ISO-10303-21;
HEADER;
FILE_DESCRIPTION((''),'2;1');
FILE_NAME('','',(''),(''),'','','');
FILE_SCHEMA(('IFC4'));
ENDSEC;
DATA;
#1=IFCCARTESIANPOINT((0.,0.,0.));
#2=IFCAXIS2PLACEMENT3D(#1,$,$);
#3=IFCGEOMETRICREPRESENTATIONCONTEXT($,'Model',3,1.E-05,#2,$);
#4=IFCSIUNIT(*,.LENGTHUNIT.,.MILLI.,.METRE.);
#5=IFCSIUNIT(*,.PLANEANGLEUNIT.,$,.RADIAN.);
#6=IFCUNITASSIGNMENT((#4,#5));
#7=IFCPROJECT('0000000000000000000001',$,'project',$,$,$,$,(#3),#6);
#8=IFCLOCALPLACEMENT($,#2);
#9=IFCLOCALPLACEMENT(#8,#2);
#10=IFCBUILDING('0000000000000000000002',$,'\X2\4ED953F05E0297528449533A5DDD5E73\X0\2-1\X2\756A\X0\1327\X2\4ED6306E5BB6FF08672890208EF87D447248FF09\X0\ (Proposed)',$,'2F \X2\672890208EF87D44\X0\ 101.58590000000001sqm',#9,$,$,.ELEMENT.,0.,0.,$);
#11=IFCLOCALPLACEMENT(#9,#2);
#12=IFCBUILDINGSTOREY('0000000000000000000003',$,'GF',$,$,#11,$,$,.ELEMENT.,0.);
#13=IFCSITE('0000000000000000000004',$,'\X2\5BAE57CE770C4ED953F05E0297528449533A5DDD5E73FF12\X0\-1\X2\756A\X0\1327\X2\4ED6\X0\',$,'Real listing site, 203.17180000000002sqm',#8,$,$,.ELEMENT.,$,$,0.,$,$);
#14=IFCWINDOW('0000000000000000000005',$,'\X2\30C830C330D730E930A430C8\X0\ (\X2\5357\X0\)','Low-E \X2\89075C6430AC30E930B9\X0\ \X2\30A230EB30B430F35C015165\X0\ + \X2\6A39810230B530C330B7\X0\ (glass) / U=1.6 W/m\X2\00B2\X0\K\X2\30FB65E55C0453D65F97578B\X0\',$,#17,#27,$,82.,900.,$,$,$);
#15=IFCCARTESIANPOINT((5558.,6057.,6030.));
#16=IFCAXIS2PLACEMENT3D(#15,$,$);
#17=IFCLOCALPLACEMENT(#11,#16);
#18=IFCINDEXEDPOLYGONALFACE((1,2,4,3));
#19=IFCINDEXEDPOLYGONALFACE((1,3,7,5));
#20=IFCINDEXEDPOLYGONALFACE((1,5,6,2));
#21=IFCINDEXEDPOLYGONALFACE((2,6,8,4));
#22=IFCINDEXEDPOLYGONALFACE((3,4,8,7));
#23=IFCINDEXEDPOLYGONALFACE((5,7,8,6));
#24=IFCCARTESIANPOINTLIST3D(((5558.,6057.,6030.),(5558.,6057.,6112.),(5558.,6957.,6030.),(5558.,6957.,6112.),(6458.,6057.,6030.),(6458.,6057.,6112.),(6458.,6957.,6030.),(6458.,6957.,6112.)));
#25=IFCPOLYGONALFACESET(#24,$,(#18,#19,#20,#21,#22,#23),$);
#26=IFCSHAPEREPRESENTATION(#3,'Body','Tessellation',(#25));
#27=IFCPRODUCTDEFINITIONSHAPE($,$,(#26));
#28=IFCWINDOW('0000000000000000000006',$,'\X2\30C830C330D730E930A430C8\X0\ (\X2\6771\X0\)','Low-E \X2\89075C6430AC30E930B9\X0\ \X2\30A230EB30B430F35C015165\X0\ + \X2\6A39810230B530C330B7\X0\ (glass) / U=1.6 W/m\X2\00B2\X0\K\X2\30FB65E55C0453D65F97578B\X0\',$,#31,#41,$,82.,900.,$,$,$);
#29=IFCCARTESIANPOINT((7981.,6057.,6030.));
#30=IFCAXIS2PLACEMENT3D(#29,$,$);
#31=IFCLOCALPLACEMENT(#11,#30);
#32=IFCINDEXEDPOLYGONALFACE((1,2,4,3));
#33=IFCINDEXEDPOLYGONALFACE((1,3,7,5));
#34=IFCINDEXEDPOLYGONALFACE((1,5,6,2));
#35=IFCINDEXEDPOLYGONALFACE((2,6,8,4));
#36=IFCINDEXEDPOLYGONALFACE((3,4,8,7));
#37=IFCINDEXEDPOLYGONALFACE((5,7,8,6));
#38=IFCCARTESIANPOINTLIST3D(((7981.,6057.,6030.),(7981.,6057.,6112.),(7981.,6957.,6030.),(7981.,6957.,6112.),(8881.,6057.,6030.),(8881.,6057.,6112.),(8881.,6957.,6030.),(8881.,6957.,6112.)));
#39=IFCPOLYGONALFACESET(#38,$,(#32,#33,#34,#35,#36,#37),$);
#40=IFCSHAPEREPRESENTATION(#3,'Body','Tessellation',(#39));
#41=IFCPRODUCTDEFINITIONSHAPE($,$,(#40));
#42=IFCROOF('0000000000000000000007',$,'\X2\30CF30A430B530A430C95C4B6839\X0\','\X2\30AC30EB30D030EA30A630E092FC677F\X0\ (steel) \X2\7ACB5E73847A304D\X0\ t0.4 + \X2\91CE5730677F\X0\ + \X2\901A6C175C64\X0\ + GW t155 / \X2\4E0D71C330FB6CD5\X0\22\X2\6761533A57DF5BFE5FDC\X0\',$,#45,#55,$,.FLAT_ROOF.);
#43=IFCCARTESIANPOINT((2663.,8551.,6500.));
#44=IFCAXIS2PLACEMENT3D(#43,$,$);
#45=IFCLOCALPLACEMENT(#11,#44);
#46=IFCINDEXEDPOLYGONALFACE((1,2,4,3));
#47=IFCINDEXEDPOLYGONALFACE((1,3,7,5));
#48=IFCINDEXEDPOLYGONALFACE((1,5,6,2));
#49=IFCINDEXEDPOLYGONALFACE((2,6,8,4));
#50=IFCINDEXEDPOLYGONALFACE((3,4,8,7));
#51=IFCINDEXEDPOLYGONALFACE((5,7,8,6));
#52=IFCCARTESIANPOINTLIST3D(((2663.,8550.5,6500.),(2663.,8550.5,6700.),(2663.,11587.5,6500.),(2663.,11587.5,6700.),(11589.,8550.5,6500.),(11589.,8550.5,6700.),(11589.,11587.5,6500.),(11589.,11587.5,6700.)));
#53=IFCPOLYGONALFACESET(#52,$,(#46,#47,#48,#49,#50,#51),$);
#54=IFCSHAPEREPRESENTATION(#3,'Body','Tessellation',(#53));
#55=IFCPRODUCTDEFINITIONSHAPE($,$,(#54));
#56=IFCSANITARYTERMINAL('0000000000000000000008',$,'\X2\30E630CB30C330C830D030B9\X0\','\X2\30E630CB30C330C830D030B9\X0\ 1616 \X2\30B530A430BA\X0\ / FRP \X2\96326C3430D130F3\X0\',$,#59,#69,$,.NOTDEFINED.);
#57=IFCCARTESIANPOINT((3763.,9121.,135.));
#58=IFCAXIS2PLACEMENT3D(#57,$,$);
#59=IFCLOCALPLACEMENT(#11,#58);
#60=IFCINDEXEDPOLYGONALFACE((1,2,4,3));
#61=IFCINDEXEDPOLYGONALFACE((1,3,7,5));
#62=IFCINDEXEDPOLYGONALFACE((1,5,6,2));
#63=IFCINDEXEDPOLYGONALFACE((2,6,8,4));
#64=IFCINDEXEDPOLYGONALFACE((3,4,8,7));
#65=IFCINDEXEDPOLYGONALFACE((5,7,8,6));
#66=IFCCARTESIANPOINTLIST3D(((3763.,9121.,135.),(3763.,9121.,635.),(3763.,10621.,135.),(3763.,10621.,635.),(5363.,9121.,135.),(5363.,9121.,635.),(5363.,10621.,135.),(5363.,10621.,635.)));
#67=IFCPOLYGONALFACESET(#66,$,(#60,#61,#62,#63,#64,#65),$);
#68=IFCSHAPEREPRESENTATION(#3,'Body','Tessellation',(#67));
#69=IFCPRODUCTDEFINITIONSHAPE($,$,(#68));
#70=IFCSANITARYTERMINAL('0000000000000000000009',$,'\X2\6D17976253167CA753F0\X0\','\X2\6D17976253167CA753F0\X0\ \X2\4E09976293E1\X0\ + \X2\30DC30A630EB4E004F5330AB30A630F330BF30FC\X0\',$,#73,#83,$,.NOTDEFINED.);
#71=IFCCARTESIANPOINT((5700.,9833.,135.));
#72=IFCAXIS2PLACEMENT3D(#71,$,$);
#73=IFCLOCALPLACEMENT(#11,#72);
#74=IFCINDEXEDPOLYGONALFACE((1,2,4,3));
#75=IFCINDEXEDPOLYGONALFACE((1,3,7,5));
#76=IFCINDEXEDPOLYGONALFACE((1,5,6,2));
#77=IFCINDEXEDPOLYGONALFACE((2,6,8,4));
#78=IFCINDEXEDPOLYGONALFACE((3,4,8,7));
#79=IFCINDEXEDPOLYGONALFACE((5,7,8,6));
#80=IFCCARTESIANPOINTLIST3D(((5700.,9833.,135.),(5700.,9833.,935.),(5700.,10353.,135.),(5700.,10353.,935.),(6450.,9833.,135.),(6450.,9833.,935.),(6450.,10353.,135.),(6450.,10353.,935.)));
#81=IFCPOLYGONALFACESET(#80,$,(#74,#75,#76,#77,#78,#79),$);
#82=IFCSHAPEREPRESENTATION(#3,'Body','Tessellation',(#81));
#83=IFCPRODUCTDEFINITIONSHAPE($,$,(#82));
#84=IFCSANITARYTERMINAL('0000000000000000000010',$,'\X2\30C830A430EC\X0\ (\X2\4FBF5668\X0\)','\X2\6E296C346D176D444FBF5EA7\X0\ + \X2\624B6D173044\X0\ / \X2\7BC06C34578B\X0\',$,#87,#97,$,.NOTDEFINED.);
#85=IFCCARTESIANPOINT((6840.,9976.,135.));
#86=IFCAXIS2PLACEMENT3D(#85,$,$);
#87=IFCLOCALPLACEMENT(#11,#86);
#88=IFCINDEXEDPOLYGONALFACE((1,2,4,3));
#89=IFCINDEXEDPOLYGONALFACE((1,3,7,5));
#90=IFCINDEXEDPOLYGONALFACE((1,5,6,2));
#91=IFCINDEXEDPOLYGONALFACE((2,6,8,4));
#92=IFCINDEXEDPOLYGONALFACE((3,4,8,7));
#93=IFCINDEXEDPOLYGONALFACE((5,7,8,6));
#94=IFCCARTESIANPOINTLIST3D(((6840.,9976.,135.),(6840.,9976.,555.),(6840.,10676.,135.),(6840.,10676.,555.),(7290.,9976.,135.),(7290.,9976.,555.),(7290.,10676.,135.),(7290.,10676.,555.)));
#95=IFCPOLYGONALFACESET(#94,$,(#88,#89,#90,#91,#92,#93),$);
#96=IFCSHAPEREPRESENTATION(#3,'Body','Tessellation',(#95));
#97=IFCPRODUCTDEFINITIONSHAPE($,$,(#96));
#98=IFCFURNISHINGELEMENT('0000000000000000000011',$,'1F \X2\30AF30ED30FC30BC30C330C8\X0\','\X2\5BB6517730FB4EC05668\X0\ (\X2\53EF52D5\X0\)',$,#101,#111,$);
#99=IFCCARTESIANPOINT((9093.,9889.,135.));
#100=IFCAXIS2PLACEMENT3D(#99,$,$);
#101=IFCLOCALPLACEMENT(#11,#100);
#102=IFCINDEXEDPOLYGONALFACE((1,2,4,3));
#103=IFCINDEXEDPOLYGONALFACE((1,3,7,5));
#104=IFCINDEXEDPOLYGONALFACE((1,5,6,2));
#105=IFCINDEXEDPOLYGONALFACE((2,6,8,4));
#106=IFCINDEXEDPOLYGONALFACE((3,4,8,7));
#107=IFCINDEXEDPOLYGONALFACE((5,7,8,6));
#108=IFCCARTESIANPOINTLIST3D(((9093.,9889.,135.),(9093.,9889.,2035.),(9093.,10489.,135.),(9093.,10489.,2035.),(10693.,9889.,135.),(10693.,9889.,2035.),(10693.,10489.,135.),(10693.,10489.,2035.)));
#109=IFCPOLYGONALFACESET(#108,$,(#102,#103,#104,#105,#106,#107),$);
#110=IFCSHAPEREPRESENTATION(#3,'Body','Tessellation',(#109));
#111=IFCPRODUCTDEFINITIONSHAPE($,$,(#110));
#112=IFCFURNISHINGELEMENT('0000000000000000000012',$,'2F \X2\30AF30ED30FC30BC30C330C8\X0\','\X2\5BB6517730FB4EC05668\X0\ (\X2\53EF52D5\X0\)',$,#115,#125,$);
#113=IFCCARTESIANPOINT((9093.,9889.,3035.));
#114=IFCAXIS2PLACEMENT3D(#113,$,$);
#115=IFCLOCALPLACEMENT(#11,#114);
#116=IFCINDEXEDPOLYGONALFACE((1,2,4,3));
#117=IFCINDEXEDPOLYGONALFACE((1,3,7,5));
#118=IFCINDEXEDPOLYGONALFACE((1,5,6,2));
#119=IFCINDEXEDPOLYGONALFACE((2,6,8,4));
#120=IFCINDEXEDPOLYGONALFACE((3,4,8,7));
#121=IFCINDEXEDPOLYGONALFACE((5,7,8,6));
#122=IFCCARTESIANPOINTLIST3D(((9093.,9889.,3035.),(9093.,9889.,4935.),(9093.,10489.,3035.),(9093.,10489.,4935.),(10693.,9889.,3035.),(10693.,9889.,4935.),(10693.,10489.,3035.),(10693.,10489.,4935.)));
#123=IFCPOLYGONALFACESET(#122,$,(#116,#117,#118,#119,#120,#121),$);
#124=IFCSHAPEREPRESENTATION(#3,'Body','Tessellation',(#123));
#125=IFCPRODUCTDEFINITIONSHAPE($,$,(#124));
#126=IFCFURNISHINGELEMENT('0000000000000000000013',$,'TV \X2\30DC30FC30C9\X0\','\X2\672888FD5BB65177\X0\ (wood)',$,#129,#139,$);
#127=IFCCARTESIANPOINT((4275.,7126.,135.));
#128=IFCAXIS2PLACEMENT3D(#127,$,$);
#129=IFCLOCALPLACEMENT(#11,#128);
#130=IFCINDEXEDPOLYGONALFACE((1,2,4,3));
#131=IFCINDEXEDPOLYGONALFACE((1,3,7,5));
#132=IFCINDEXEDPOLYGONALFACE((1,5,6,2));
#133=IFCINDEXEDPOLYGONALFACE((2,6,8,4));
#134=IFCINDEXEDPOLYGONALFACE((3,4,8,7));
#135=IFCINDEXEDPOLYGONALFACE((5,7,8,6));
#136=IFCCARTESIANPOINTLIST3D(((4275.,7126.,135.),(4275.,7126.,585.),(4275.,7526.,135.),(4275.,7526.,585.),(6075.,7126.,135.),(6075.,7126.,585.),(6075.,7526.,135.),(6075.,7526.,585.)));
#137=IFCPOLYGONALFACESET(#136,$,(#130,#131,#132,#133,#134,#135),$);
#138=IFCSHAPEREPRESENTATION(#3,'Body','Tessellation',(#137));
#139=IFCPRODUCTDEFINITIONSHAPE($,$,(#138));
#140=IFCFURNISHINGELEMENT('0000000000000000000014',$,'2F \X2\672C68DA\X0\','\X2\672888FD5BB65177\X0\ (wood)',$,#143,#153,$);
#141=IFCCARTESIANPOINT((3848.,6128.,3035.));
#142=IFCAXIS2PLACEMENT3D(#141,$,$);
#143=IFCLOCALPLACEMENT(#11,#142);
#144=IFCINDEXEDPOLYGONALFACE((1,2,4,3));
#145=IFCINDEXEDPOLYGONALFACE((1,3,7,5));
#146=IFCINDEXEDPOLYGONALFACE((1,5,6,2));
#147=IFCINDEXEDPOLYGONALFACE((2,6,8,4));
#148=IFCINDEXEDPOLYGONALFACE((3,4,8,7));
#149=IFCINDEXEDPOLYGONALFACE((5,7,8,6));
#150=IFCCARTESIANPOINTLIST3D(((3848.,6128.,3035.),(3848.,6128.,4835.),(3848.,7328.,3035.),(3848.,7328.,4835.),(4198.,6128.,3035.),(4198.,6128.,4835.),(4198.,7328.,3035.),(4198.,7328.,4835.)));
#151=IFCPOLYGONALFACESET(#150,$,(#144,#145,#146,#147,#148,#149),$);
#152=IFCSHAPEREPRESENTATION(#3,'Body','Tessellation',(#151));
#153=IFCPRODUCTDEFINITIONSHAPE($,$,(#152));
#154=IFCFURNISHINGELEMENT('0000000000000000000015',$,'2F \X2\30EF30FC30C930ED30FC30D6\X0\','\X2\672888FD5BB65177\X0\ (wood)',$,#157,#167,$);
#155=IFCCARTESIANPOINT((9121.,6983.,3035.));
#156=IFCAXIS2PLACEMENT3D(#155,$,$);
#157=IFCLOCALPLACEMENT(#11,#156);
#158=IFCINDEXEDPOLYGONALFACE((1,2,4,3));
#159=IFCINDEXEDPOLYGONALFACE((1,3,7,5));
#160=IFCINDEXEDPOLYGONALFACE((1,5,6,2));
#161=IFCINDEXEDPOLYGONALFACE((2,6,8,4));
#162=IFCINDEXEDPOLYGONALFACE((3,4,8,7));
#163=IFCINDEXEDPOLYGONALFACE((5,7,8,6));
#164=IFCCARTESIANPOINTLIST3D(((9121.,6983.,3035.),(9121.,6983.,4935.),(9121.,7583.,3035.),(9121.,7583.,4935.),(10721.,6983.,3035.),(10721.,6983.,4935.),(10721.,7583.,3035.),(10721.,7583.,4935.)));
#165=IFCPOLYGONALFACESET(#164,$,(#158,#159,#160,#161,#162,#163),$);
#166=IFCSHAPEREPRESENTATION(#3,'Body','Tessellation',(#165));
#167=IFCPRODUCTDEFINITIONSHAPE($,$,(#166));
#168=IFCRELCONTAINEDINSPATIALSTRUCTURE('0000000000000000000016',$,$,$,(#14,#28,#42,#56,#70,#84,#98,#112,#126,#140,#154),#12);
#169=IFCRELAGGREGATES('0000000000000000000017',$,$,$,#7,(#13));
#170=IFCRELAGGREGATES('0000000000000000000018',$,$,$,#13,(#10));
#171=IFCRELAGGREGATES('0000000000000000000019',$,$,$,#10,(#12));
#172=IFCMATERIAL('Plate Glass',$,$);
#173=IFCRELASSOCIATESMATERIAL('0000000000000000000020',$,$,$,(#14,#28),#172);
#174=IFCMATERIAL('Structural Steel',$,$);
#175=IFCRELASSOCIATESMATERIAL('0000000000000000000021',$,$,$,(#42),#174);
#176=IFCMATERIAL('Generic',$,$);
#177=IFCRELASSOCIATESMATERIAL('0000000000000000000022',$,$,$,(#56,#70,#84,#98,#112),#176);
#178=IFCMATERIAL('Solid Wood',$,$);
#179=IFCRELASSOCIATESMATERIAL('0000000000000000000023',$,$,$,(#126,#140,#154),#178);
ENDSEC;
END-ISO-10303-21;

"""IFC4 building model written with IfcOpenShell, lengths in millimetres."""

from ifc_helpers import new_model, si_unit, frame, frame_2d, origin, place, context, project, spatial, rectangle, extrude, material, element, save


model = new_model("IFC4")

# Units and contexts
model_context = context("Model", 3, precision=1e-05, world=origin())
ifc_project = project(units=[si_unit("LENGTHUNIT", "METRE", prefix="MILLI"), si_unit("PLANEANGLEUNIT", "RADIAN")], contexts=[model_context])

# Site, building, storey
site_placement = place(None, origin())
site = spatial("IfcSite", under=ifc_project, at=site_placement, Name="宮城県仙台市青葉区川平２-1番1327他", ObjectType="Real listing site, 203.17180000000002sqm", CompositionType="ELEMENT", RefElevation=0.0)
building_placement = place(site_placement, origin())
building = spatial("IfcBuilding", under=site, at=building_placement, Name="仙台市青葉区川平2-1番1327他の家（木造軸組版） (Proposed)", ObjectType="2F 木造軸組 101.58590000000001sqm", CompositionType="ELEMENT", ElevationOfRefHeight=0.0, ElevationOfTerrain=0.0)
storey_placement = place(building_placement, origin())
storey = spatial("IfcBuildingStorey", under=building, at=storey_placement, Name="GF", CompositionType="ELEMENT", Elevation=0.0)

# Shared definitions
ifc_material_1 = material(Name="Solid Wood")
ifc_material_2 = material(Name="Plate Glass")

# Windows
window_1_placement = place(storey_placement, frame((5558.0, 6057.0, 6030.0)))
element("IfcWindow", 1, at=window_1_placement, inside=storey, material=ifc_material_2, Name="トップライト (南)", Description="Low-E 複層ガラス アルゴン封入 + 樹脂サッシ (glass) / U=1.6 W/m²K・日射取得型", OverallHeight=82.0, OverallWidth=900.0, context=model_context, shape_type="SweptSolid", body=[
    extrude(rectangle(XDim=900.0, YDim=900.0, at=frame_2d((450.0, 450.0))), frame((5558.0, 6057.0, 6030.0)), (0.0, 0.0, 1.0), 82.0),
])
window_2_placement = place(storey_placement, frame((7981.0, 6057.0, 6030.0)))
element("IfcWindow", 2, at=window_2_placement, inside=storey, material=ifc_material_2, Name="トップライト (東)", Description="Low-E 複層ガラス アルゴン封入 + 樹脂サッシ (glass) / U=1.6 W/m²K・日射取得型", OverallHeight=82.0, OverallWidth=900.0, context=model_context, shape_type="SweptSolid", body=[
    extrude(rectangle(XDim=900.0, YDim=900.0, at=frame_2d((450.0, 450.0))), frame((7981.0, 6057.0, 6030.0)), (0.0, 0.0, 1.0), 82.0),
])

# Roof
ifc_material_3 = material(Name="Structural Steel")
roof_placement = place(storey_placement, frame((2663.0, 8551.0, 6500.0)))
element("IfcRoof", 3, at=roof_placement, inside=storey, material=ifc_material_3, Name="ハイサイド屋根", Description="ガルバリウム鋼板 (steel) 立平葺き t0.4 + 野地板 + 通気層 + GW t155 / 不燃・法22条区域対応", PredefinedType="FLAT_ROOF", context=model_context, shape_type="SweptSolid", body=[
    extrude(rectangle(XDim=8926.0, YDim=3037.0, at=frame_2d((4463.0, 1518.0))), frame((2663.0, 8551.0, 6500.0)), (0.0, 0.0, 1.0), 200.0),
])

# Sanitary terminals
ifc_material_4 = material(Name="Generic")
sanitary_terminal_1_placement = place(storey_placement, frame((3763.0, 9121.0, 135.0)))
element("IfcSanitaryTerminal", 4, at=sanitary_terminal_1_placement, inside=storey, material=ifc_material_4, Name="ユニットバス", Description="ユニットバス 1616 サイズ / FRP 防水パン", PredefinedType="NOTDEFINED", context=model_context, shape_type="SweptSolid", body=[
    extrude(rectangle(XDim=1600.0, YDim=1500.0, at=frame_2d((800.0, 750.0))), frame((3763.0, 9121.0, 135.0)), (0.0, 0.0, 1.0), 500.0),
])
sanitary_terminal_2_placement = place(storey_placement, frame((5700.0, 9833.0, 135.0)))
element("IfcSanitaryTerminal", 5, at=sanitary_terminal_2_placement, inside=storey, material=ifc_material_4, Name="洗面化粧台", Description="洗面化粧台 三面鏡 + ボウル一体カウンター", PredefinedType="NOTDEFINED", context=model_context, shape_type="SweptSolid", body=[
    extrude(rectangle(XDim=750.0, YDim=520.0, at=frame_2d((375.0, 260.0))), frame((5700.0, 9833.0, 135.0)), (0.0, 0.0, 1.0), 800.0),
])
sanitary_terminal_3_placement = place(storey_placement, frame((6840.0, 9976.0, 135.0)))
element("IfcSanitaryTerminal", 6, at=sanitary_terminal_3_placement, inside=storey, material=ifc_material_4, Name="トイレ (便器)", Description="温水洗浄便座 + 手洗い / 節水型", PredefinedType="NOTDEFINED", context=model_context, shape_type="SweptSolid", body=[
    extrude(rectangle(XDim=450.0, YDim=700.0, at=frame_2d((225.0, 350.0))), frame((6840.0, 9976.0, 135.0)), (0.0, 0.0, 1.0), 420.0),
])

# Furnishing elements
furnishing_1_placement = place(storey_placement, frame((9093.0, 9889.0, 135.0)))
element("IfcFurnishingElement", 7, at=furnishing_1_placement, inside=storey, material=ifc_material_4, Name="1F クローゼット", Description="家具・什器 (可動)", context=model_context, shape_type="SweptSolid", body=[
    extrude(rectangle(XDim=1600.0, YDim=600.0, at=frame_2d((800.0, 300.0))), frame((9093.0, 9889.0, 135.0)), (0.0, 0.0, 1.0), 1900.0),
])
furnishing_2_placement = place(storey_placement, frame((9093.0, 9889.0, 3035.0)))
element("IfcFurnishingElement", 8, at=furnishing_2_placement, inside=storey, material=ifc_material_4, Name="2F クローゼット", Description="家具・什器 (可動)", context=model_context, shape_type="SweptSolid", body=[
    extrude(rectangle(XDim=1600.0, YDim=600.0, at=frame_2d((800.0, 300.0))), frame((9093.0, 9889.0, 3035.0)), (0.0, 0.0, 1.0), 1900.0),
])
furnishing_3_placement = place(storey_placement, frame((4275.0, 7126.0, 135.0)))
element("IfcFurnishingElement", 9, at=furnishing_3_placement, inside=storey, material=ifc_material_1, Name="TV ボード", Description="木製家具 (wood)", context=model_context, shape_type="SweptSolid", body=[
    extrude(rectangle(XDim=1800.0, YDim=400.0, at=frame_2d((900.0, 200.0))), frame((4275.0, 7126.0, 135.0)), (0.0, 0.0, 1.0), 450.0),
])
furnishing_4_placement = place(storey_placement, frame((3848.0, 6128.0, 3035.0)))
element("IfcFurnishingElement", 10, at=furnishing_4_placement, inside=storey, material=ifc_material_1, Name="2F 本棚", Description="木製家具 (wood)", context=model_context, shape_type="SweptSolid", body=[
    extrude(rectangle(XDim=350.0, YDim=1200.0, at=frame_2d((175.0, 600.0))), frame((3848.0, 6128.0, 3035.0)), (0.0, 0.0, 1.0), 1800.0),
])
furnishing_5_placement = place(storey_placement, frame((9121.0, 6983.0, 3035.0)))
element("IfcFurnishingElement", 11, at=furnishing_5_placement, inside=storey, material=ifc_material_1, Name="2F ワードローブ", Description="木製家具 (wood)", context=model_context, shape_type="SweptSolid", body=[
    extrude(rectangle(XDim=1600.0, YDim=600.0, at=frame_2d((800.0, 300.0))), frame((9121.0, 6983.0, 3035.0)), (0.0, 0.0, 1.0), 1900.0),
])

save(model, "model.ifc")
